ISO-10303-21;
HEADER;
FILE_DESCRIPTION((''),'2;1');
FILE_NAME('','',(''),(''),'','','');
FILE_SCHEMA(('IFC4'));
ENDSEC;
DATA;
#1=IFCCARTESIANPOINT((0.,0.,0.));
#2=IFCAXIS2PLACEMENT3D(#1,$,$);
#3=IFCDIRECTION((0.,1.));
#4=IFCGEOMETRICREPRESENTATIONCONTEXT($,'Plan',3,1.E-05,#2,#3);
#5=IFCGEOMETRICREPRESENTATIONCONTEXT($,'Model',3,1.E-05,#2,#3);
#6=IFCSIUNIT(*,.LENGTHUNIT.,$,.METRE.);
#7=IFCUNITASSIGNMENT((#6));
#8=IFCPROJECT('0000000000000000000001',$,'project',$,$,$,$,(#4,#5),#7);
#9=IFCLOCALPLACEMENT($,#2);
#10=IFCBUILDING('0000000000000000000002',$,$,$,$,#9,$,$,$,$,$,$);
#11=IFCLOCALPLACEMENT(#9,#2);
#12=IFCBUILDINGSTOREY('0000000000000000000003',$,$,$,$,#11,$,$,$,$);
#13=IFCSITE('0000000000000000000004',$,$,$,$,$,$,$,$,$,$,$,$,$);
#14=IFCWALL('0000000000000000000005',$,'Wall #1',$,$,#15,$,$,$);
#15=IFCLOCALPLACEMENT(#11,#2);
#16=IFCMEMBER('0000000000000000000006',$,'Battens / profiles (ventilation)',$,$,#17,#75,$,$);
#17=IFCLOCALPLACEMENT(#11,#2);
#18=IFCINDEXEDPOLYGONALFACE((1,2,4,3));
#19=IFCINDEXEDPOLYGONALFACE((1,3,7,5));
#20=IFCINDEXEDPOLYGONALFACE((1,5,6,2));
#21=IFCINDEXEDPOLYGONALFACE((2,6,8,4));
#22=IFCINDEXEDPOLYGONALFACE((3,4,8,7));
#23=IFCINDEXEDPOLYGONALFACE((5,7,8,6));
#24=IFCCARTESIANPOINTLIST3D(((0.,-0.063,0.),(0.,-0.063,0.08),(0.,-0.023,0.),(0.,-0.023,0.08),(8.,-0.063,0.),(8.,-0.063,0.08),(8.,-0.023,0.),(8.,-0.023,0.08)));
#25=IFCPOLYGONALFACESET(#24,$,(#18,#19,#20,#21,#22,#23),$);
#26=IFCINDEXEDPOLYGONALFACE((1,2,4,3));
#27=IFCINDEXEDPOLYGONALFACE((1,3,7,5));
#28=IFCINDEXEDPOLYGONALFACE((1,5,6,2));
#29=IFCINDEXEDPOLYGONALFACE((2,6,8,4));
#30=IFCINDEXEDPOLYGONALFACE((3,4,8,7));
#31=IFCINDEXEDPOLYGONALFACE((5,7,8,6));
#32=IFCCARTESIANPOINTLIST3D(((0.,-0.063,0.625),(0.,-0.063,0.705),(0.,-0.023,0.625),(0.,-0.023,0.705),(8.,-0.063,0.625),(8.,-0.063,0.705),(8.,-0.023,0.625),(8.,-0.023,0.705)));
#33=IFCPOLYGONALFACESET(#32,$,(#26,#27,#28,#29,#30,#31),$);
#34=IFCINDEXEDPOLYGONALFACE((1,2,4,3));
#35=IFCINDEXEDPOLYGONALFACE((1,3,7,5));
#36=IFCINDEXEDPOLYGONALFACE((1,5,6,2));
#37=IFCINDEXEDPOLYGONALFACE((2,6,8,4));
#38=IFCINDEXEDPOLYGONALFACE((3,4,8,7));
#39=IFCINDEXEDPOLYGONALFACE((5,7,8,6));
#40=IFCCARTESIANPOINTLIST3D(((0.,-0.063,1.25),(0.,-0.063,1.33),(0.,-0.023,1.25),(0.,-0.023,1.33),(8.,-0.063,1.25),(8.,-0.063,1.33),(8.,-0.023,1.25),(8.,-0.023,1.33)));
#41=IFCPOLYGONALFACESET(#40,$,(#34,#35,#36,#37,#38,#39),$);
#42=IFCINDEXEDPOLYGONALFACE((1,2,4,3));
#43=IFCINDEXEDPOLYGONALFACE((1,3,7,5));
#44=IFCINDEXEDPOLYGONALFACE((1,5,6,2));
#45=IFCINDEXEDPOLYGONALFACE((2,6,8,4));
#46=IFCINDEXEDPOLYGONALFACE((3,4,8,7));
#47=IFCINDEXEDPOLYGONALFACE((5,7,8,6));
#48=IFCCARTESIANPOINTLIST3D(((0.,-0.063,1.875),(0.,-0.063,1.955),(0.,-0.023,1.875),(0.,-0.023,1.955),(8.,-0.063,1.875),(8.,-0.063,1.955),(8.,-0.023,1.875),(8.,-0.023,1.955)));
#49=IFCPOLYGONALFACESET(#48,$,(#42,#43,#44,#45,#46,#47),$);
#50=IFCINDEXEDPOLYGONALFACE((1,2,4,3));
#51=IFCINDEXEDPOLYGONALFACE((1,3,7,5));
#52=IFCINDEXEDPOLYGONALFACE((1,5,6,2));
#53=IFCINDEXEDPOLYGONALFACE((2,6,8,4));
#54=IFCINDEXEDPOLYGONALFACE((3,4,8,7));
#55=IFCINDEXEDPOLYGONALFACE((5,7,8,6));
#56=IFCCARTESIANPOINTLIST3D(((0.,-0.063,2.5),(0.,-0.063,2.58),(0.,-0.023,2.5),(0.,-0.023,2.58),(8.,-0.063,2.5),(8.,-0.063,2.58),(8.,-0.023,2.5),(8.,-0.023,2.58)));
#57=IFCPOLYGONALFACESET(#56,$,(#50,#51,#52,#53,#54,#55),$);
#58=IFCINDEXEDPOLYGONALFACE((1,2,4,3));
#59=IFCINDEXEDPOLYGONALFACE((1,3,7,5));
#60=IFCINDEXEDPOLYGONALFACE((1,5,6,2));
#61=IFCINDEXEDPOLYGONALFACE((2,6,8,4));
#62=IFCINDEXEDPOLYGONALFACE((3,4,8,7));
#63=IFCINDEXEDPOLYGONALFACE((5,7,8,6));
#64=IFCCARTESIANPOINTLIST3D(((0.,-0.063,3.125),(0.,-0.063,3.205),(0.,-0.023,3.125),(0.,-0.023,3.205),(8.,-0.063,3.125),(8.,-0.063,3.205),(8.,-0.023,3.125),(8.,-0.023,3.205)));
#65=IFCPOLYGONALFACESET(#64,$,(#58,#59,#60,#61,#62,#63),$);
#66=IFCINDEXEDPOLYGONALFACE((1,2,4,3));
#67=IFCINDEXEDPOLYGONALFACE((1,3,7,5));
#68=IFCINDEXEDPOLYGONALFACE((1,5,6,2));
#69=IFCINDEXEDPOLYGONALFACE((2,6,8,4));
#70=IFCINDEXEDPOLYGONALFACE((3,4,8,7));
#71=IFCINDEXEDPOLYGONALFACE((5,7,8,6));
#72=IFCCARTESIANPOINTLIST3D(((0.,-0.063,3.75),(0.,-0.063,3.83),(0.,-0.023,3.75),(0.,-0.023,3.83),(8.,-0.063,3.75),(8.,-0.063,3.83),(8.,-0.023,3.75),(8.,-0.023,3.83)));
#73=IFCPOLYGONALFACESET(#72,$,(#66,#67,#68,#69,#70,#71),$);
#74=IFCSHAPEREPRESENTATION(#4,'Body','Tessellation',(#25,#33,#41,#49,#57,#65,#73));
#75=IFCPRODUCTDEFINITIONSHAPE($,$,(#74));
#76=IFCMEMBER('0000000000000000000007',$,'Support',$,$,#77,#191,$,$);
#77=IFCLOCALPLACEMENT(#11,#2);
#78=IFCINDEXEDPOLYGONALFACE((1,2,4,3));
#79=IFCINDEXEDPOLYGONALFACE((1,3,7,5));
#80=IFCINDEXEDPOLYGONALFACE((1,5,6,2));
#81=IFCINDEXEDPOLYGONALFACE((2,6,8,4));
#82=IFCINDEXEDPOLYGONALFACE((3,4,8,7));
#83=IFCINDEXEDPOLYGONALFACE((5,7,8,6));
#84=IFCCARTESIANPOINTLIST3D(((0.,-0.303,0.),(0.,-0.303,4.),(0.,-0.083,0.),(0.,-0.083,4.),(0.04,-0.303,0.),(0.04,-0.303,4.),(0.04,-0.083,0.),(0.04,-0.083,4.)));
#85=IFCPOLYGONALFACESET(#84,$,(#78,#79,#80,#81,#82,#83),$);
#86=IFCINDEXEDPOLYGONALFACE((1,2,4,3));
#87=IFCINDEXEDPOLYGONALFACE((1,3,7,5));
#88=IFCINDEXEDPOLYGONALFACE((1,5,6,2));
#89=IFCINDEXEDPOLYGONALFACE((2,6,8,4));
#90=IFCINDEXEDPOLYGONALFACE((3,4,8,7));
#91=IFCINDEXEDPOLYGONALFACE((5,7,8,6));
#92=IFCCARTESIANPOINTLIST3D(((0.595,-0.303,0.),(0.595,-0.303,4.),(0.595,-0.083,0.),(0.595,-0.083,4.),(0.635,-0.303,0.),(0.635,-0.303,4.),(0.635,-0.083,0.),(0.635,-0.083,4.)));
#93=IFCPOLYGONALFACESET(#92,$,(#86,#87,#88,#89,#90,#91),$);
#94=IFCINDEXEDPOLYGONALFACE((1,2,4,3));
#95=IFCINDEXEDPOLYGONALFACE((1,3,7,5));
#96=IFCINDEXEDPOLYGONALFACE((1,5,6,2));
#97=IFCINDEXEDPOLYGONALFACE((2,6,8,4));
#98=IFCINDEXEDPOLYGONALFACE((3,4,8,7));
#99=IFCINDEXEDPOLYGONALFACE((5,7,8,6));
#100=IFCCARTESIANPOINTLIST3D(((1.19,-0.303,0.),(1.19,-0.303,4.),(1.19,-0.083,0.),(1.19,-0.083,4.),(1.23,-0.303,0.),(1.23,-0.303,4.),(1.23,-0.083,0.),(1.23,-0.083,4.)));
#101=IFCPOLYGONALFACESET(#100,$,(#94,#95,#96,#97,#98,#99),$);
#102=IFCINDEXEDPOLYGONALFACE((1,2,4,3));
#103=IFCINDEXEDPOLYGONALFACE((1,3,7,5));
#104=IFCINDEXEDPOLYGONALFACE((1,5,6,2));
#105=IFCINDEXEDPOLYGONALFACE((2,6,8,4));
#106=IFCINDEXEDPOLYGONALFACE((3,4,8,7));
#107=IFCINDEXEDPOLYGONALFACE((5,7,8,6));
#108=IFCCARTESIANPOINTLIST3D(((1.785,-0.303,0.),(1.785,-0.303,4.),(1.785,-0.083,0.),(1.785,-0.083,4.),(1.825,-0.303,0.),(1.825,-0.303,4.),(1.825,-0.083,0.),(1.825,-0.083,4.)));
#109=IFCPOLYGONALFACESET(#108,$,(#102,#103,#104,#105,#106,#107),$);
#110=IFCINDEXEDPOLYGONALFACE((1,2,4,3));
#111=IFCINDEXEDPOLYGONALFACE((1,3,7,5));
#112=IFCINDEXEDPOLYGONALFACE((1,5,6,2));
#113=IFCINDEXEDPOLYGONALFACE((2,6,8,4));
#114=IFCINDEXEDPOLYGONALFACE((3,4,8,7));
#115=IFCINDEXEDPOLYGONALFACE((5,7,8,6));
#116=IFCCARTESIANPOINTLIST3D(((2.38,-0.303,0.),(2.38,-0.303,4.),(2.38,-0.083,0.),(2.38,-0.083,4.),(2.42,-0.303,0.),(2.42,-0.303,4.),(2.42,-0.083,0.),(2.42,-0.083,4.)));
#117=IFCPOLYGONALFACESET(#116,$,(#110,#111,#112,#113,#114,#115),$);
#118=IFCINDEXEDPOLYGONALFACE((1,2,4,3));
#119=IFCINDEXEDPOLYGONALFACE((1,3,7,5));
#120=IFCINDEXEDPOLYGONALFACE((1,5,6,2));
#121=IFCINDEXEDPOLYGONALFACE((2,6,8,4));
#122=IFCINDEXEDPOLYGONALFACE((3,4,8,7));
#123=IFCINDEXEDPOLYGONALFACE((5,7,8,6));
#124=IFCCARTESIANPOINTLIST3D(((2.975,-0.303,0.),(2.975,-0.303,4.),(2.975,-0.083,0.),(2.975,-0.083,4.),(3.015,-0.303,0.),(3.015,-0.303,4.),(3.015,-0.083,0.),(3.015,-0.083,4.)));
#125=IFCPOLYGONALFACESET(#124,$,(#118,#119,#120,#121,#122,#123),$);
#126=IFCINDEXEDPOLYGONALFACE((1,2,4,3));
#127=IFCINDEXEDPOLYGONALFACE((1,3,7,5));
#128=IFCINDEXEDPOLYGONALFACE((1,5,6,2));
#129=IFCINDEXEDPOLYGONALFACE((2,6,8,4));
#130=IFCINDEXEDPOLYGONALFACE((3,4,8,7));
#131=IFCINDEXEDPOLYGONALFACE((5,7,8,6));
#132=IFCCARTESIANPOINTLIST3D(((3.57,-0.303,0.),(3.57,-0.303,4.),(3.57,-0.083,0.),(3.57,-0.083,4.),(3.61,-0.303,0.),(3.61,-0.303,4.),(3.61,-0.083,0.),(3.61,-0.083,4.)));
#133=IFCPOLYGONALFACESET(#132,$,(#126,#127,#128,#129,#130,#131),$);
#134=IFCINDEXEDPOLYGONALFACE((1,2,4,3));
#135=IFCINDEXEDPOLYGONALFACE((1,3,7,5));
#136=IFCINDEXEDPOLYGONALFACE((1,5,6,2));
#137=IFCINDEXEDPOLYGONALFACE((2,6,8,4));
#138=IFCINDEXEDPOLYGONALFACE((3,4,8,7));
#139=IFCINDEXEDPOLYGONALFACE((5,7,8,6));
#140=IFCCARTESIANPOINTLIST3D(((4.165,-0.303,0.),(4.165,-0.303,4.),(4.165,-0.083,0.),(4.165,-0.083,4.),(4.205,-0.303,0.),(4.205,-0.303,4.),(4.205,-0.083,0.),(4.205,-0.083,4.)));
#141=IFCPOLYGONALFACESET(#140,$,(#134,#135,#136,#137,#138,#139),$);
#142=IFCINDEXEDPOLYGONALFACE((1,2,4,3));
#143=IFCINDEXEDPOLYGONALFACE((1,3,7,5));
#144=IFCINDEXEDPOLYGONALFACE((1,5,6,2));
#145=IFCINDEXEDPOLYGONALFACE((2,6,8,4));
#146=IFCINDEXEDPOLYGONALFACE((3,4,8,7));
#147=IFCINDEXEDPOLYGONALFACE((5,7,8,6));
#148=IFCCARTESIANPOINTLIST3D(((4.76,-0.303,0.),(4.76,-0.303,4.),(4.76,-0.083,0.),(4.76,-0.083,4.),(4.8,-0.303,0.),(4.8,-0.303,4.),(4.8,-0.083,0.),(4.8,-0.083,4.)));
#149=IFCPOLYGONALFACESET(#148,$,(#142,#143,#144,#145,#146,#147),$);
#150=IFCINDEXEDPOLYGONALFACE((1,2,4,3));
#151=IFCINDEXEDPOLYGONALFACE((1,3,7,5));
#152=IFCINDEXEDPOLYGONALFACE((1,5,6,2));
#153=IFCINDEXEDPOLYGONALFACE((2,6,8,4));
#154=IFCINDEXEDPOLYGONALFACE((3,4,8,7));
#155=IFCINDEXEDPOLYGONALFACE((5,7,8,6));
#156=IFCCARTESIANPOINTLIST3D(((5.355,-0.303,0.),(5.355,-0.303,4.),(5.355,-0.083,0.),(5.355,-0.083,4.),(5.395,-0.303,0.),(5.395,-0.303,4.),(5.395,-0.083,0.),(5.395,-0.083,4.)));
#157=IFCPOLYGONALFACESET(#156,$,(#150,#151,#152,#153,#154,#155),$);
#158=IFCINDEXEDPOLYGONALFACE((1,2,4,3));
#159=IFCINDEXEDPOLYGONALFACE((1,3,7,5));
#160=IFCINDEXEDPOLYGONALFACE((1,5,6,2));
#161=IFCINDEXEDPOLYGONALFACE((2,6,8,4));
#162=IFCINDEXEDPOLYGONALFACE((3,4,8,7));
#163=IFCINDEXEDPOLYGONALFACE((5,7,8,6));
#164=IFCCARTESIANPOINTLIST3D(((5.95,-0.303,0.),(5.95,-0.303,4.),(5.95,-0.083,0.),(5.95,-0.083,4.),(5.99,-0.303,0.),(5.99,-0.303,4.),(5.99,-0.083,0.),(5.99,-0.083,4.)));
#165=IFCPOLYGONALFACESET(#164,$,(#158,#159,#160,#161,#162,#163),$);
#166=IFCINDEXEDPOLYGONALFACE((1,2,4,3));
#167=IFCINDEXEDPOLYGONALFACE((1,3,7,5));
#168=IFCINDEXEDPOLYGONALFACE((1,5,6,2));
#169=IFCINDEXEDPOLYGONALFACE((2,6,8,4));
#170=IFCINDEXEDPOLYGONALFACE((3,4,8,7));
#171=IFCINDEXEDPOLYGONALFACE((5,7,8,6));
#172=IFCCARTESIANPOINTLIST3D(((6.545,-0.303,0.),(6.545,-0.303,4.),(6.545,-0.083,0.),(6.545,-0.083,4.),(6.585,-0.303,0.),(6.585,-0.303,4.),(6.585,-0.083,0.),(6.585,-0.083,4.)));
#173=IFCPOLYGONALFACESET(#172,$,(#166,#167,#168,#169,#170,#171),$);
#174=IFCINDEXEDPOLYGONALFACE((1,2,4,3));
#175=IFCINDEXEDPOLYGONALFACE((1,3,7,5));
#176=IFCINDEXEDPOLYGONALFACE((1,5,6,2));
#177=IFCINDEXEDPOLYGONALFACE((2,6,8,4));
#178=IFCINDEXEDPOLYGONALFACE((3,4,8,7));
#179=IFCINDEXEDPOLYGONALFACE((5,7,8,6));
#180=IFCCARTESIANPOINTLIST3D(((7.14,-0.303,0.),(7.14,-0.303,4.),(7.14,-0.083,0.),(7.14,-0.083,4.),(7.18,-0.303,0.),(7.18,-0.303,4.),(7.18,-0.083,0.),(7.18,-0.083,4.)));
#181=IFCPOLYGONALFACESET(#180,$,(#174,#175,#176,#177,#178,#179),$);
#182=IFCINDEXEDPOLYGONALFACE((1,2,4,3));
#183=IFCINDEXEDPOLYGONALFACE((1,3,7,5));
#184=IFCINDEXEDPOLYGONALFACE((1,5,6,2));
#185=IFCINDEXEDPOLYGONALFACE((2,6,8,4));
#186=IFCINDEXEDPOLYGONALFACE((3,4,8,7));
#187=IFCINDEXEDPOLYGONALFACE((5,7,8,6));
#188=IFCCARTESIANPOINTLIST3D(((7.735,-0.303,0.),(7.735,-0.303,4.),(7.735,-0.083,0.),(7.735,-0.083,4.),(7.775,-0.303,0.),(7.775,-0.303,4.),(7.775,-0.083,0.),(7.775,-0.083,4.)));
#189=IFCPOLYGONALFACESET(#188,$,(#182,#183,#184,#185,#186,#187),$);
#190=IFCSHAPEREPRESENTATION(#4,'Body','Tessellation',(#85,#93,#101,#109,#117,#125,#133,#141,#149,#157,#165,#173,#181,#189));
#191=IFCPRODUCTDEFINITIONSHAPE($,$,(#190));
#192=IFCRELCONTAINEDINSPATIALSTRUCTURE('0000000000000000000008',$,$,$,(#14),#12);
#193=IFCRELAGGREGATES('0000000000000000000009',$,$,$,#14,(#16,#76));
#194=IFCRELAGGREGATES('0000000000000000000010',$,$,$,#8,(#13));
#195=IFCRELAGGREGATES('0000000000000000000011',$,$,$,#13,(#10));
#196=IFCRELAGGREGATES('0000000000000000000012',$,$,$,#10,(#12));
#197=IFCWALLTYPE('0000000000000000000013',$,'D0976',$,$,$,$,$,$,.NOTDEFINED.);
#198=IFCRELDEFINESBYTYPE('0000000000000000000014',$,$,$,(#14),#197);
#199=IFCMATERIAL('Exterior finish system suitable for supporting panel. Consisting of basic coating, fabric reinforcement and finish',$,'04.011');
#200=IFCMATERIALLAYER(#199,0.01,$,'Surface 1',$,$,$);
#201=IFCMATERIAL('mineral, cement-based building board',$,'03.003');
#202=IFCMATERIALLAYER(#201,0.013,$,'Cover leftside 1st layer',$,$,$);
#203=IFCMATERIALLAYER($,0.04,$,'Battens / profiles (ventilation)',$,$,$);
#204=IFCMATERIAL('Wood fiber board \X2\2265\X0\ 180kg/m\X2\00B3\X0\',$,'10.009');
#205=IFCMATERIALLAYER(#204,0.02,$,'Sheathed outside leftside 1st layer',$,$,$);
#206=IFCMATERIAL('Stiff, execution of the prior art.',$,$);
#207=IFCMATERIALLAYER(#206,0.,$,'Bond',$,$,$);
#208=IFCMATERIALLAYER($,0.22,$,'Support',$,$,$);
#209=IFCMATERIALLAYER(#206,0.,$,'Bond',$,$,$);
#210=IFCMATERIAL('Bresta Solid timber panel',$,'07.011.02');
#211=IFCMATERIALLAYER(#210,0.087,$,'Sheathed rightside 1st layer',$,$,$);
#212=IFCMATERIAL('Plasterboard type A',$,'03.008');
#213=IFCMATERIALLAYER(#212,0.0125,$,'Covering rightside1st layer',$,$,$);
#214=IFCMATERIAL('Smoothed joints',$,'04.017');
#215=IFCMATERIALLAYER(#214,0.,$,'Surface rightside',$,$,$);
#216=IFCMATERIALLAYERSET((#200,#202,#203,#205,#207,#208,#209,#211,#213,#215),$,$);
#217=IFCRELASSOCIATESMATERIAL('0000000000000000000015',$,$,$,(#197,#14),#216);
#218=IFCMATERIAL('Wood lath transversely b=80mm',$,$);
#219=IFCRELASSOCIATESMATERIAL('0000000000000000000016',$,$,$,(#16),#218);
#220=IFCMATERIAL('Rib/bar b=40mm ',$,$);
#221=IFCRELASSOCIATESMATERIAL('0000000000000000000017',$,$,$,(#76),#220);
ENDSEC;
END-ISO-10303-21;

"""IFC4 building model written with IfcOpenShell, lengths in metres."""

from ifc_helpers import new_model, si_unit, direction, frame, frame_2d, origin, place, context, project, spatial, rectangle, extrude, material, layer, layer_set, type_object, element, aggregate, save


model = new_model("IFC4")

# Units and contexts
plan_context = context("Plan", 3, precision=1e-05, world=origin(), true_north=direction((0.0, 1.0)))
model_context = context("Model", 3, precision=1e-05, world=origin(), true_north=direction((0.0, 1.0)))
ifc_project = project(units=[si_unit("LENGTHUNIT", "METRE")], contexts=[plan_context, model_context])

# Site, building, storey
site = spatial("IfcSite", under=ifc_project)
building_placement = place(None, origin())
building = spatial("IfcBuilding", under=site, at=building_placement)
storey_placement = place(building_placement, origin())
storey = spatial("IfcBuildingStorey", under=building, at=storey_placement)

# Wall, members
ifc_material_1 = material(Name="Exterior finish system suitable for supporting panel. Consisting of basic coating, fabric reinforcement and finish", Category="04.011")
ifc_layer_1 = layer(ifc_material_1, 0.01, Name="Surface 1")
ifc_material_2 = material(Name="mineral, cement-based building board", Category="03.003")
ifc_layer_2 = layer(ifc_material_2, 0.013, Name="Cover leftside 1st layer")
ifc_layer_3 = layer(None, 0.04, Name="Battens / profiles (ventilation)")
ifc_material_3 = material(Name="Wood fiber board ≥ 180kg/m³", Category="10.009")
ifc_layer_4 = layer(ifc_material_3, 0.02, Name="Sheathed outside leftside 1st layer")
ifc_material_4 = material(Name="Stiff, execution of the prior art.")
ifc_layer_5 = layer(ifc_material_4, 0.0, Name="Bond")
ifc_layer_6 = layer(None, 0.22, Name="Support")
ifc_layer_7 = layer(ifc_material_4, 0.0, Name="Bond")
ifc_material_5 = material(Name="Bresta Solid timber panel", Category="07.011.02")
ifc_layer_8 = layer(ifc_material_5, 0.087, Name="Sheathed rightside 1st layer")
ifc_material_6 = material(Name="Plasterboard type A", Category="03.008")
ifc_layer_9 = layer(ifc_material_6, 0.0125, Name="Covering rightside1st layer")
ifc_material_7 = material(Name="Smoothed joints", Category="04.017")
ifc_layer_10 = layer(ifc_material_7, 0.0, Name="Surface rightside")
ifc_layer_set = layer_set([ifc_layer_1, ifc_layer_2, ifc_layer_3, ifc_layer_4, ifc_layer_5, ifc_layer_6, ifc_layer_7, ifc_layer_8, ifc_layer_9, ifc_layer_10])
wall_type = type_object("IfcWallType", Name="D0976", PredefinedType="NOTDEFINED", material=ifc_layer_set)
wall_placement = place(None, frame((0.0, 0.0, 0.0), z_axis=(0.0, -1.0, 0.0), x_axis=(1.0, 0.0, 0.0)))
wall = element("IfcWall", 1, at=wall_placement, inside=storey, type_object=wall_type, material=ifc_layer_set, Name="Wall #1")
ifc_material_8 = material(Name="Wood lath transversely b=80mm")
member_1_placement = place(wall_placement, origin())
member_1 = element("IfcMember", 2, at=member_1_placement, material=ifc_material_8, Name="Battens / profiles (ventilation)", context=plan_context, shape_type="SweptSolid", body=[
    extrude(rectangle(XDim=0.08, YDim=0.04, at=frame_2d((0.04, 0.02), x_axis=(1.0, 0.0))), frame((0.0, 0.0, 0.023), z_axis=(1.0, 0.0, 0.0), x_axis=(0.0, 1.0, 0.0)), (0.0, 0.0, 1.0), 8.0),
    extrude(rectangle(XDim=0.08, YDim=0.04, at=frame_2d((0.04, 0.02), x_axis=(1.0, 0.0))), frame((0.0, 0.625, 0.023), z_axis=(1.0, 0.0, 0.0), x_axis=(0.0, 1.0, 0.0)), (0.0, 0.0, 1.0), 8.0),
    extrude(rectangle(XDim=0.08, YDim=0.04, at=frame_2d((0.04, 0.02), x_axis=(1.0, 0.0))), frame((0.0, 1.25, 0.023), z_axis=(1.0, 0.0, 0.0), x_axis=(0.0, 1.0, 0.0)), (0.0, 0.0, 1.0), 8.0),
    extrude(rectangle(XDim=0.08, YDim=0.04, at=frame_2d((0.04, 0.02), x_axis=(1.0, 0.0))), frame((0.0, 1.875, 0.023), z_axis=(1.0, 0.0, 0.0), x_axis=(0.0, 1.0, 0.0)), (0.0, 0.0, 1.0), 8.0),
    extrude(rectangle(XDim=0.08, YDim=0.04, at=frame_2d((0.04, 0.02), x_axis=(1.0, 0.0))), frame((0.0, 2.5, 0.023), z_axis=(1.0, 0.0, 0.0), x_axis=(0.0, 1.0, 0.0)), (0.0, 0.0, 1.0), 8.0),
    extrude(rectangle(XDim=0.08, YDim=0.04, at=frame_2d((0.04, 0.02), x_axis=(1.0, 0.0))), frame((0.0, 3.125, 0.023), z_axis=(1.0, 0.0, 0.0), x_axis=(0.0, 1.0, 0.0)), (0.0, 0.0, 1.0), 8.0),
    extrude(rectangle(XDim=0.08, YDim=0.04, at=frame_2d((0.04, 0.02), x_axis=(1.0, 0.0))), frame((0.0, 3.75, 0.023), z_axis=(1.0, 0.0, 0.0), x_axis=(0.0, 1.0, 0.0)), (0.0, 0.0, 1.0), 8.0),
])
ifc_material_9 = material(Name="Rib/bar b=40mm ")
member_2_placement = place(wall_placement, origin())
member_2 = element("IfcMember", 3, at=member_2_placement, material=ifc_material_9, Name="Support", context=plan_context, shape_type="SweptSolid", body=[
    extrude(rectangle(XDim=0.04, YDim=0.22, at=frame_2d((0.02, 0.11), x_axis=(1.0, 0.0))), frame((0.0, 4.0, 0.083), z_axis=(0.0, -1.0, 0.0), x_axis=(1.0, 0.0, 0.0)), (0.0, 0.0, 1.0), 4.0),
    extrude(rectangle(XDim=0.04, YDim=0.22, at=frame_2d((0.02, 0.11), x_axis=(1.0, 0.0))), frame((0.595, 4.0, 0.083), z_axis=(0.0, -1.0, 0.0), x_axis=(1.0, 0.0, 0.0)), (0.0, 0.0, 1.0), 4.0),
    extrude(rectangle(XDim=0.04, YDim=0.22, at=frame_2d((0.02, 0.11), x_axis=(1.0, 0.0))), frame((1.19, 4.0, 0.083), z_axis=(0.0, -1.0, 0.0), x_axis=(1.0, 0.0, 0.0)), (0.0, 0.0, 1.0), 4.0),
    extrude(rectangle(XDim=0.04, YDim=0.22, at=frame_2d((0.02, 0.11), x_axis=(1.0, 0.0))), frame((1.785, 4.0, 0.083), z_axis=(0.0, -1.0, 0.0), x_axis=(1.0, 0.0, 0.0)), (0.0, 0.0, 1.0), 4.0),
    extrude(rectangle(XDim=0.04, YDim=0.22, at=frame_2d((0.02, 0.11), x_axis=(1.0, 0.0))), frame((2.38, 4.0, 0.083), z_axis=(0.0, -1.0, 0.0), x_axis=(1.0, 0.0, 0.0)), (0.0, 0.0, 1.0), 4.0),
    extrude(rectangle(XDim=0.04, YDim=0.22, at=frame_2d((0.02, 0.11), x_axis=(1.0, 0.0))), frame((2.975, 4.0, 0.083), z_axis=(0.0, -1.0, 0.0), x_axis=(1.0, 0.0, 0.0)), (0.0, 0.0, 1.0), 4.0),
    extrude(rectangle(XDim=0.04, YDim=0.22, at=frame_2d((0.02, 0.11), x_axis=(1.0, 0.0))), frame((3.57, 4.0, 0.083), z_axis=(0.0, -1.0, 0.0), x_axis=(1.0, 0.0, 0.0)), (0.0, 0.0, 1.0), 4.0),
    extrude(rectangle(XDim=0.04, YDim=0.22, at=frame_2d((0.02, 0.11), x_axis=(1.0, 0.0))), frame((4.165, 4.0, 0.083), z_axis=(0.0, -1.0, 0.0), x_axis=(1.0, 0.0, 0.0)), (0.0, 0.0, 1.0), 4.0),
    extrude(rectangle(XDim=0.04, YDim=0.22, at=frame_2d((0.02, 0.11), x_axis=(1.0, 0.0))), frame((4.76, 4.0, 0.083), z_axis=(0.0, -1.0, 0.0), x_axis=(1.0, 0.0, 0.0)), (0.0, 0.0, 1.0), 4.0),
    extrude(rectangle(XDim=0.04, YDim=0.22, at=frame_2d((0.02, 0.11), x_axis=(1.0, 0.0))), frame((5.355, 4.0, 0.083), z_axis=(0.0, -1.0, 0.0), x_axis=(1.0, 0.0, 0.0)), (0.0, 0.0, 1.0), 4.0),
    extrude(rectangle(XDim=0.04, YDim=0.22, at=frame_2d((0.02, 0.11), x_axis=(1.0, 0.0))), frame((5.95, 4.0, 0.083), z_axis=(0.0, -1.0, 0.0), x_axis=(1.0, 0.0, 0.0)), (0.0, 0.0, 1.0), 4.0),
    extrude(rectangle(XDim=0.04, YDim=0.22, at=frame_2d((0.02, 0.11), x_axis=(1.0, 0.0))), frame((6.545, 4.0, 0.083), z_axis=(0.0, -1.0, 0.0), x_axis=(1.0, 0.0, 0.0)), (0.0, 0.0, 1.0), 4.0),
    extrude(rectangle(XDim=0.04, YDim=0.22, at=frame_2d((0.02, 0.11), x_axis=(1.0, 0.0))), frame((7.14, 4.0, 0.083), z_axis=(0.0, -1.0, 0.0), x_axis=(1.0, 0.0, 0.0)), (0.0, 0.0, 1.0), 4.0),
    extrude(rectangle(XDim=0.04, YDim=0.22, at=frame_2d((0.02, 0.11), x_axis=(1.0, 0.0))), frame((7.735, 4.0, 0.083), z_axis=(0.0, -1.0, 0.0), x_axis=(1.0, 0.0, 0.0)), (0.0, 0.0, 1.0), 4.0),
])
aggregate(wall, [member_1, member_2])

save(model, "model.ifc")
